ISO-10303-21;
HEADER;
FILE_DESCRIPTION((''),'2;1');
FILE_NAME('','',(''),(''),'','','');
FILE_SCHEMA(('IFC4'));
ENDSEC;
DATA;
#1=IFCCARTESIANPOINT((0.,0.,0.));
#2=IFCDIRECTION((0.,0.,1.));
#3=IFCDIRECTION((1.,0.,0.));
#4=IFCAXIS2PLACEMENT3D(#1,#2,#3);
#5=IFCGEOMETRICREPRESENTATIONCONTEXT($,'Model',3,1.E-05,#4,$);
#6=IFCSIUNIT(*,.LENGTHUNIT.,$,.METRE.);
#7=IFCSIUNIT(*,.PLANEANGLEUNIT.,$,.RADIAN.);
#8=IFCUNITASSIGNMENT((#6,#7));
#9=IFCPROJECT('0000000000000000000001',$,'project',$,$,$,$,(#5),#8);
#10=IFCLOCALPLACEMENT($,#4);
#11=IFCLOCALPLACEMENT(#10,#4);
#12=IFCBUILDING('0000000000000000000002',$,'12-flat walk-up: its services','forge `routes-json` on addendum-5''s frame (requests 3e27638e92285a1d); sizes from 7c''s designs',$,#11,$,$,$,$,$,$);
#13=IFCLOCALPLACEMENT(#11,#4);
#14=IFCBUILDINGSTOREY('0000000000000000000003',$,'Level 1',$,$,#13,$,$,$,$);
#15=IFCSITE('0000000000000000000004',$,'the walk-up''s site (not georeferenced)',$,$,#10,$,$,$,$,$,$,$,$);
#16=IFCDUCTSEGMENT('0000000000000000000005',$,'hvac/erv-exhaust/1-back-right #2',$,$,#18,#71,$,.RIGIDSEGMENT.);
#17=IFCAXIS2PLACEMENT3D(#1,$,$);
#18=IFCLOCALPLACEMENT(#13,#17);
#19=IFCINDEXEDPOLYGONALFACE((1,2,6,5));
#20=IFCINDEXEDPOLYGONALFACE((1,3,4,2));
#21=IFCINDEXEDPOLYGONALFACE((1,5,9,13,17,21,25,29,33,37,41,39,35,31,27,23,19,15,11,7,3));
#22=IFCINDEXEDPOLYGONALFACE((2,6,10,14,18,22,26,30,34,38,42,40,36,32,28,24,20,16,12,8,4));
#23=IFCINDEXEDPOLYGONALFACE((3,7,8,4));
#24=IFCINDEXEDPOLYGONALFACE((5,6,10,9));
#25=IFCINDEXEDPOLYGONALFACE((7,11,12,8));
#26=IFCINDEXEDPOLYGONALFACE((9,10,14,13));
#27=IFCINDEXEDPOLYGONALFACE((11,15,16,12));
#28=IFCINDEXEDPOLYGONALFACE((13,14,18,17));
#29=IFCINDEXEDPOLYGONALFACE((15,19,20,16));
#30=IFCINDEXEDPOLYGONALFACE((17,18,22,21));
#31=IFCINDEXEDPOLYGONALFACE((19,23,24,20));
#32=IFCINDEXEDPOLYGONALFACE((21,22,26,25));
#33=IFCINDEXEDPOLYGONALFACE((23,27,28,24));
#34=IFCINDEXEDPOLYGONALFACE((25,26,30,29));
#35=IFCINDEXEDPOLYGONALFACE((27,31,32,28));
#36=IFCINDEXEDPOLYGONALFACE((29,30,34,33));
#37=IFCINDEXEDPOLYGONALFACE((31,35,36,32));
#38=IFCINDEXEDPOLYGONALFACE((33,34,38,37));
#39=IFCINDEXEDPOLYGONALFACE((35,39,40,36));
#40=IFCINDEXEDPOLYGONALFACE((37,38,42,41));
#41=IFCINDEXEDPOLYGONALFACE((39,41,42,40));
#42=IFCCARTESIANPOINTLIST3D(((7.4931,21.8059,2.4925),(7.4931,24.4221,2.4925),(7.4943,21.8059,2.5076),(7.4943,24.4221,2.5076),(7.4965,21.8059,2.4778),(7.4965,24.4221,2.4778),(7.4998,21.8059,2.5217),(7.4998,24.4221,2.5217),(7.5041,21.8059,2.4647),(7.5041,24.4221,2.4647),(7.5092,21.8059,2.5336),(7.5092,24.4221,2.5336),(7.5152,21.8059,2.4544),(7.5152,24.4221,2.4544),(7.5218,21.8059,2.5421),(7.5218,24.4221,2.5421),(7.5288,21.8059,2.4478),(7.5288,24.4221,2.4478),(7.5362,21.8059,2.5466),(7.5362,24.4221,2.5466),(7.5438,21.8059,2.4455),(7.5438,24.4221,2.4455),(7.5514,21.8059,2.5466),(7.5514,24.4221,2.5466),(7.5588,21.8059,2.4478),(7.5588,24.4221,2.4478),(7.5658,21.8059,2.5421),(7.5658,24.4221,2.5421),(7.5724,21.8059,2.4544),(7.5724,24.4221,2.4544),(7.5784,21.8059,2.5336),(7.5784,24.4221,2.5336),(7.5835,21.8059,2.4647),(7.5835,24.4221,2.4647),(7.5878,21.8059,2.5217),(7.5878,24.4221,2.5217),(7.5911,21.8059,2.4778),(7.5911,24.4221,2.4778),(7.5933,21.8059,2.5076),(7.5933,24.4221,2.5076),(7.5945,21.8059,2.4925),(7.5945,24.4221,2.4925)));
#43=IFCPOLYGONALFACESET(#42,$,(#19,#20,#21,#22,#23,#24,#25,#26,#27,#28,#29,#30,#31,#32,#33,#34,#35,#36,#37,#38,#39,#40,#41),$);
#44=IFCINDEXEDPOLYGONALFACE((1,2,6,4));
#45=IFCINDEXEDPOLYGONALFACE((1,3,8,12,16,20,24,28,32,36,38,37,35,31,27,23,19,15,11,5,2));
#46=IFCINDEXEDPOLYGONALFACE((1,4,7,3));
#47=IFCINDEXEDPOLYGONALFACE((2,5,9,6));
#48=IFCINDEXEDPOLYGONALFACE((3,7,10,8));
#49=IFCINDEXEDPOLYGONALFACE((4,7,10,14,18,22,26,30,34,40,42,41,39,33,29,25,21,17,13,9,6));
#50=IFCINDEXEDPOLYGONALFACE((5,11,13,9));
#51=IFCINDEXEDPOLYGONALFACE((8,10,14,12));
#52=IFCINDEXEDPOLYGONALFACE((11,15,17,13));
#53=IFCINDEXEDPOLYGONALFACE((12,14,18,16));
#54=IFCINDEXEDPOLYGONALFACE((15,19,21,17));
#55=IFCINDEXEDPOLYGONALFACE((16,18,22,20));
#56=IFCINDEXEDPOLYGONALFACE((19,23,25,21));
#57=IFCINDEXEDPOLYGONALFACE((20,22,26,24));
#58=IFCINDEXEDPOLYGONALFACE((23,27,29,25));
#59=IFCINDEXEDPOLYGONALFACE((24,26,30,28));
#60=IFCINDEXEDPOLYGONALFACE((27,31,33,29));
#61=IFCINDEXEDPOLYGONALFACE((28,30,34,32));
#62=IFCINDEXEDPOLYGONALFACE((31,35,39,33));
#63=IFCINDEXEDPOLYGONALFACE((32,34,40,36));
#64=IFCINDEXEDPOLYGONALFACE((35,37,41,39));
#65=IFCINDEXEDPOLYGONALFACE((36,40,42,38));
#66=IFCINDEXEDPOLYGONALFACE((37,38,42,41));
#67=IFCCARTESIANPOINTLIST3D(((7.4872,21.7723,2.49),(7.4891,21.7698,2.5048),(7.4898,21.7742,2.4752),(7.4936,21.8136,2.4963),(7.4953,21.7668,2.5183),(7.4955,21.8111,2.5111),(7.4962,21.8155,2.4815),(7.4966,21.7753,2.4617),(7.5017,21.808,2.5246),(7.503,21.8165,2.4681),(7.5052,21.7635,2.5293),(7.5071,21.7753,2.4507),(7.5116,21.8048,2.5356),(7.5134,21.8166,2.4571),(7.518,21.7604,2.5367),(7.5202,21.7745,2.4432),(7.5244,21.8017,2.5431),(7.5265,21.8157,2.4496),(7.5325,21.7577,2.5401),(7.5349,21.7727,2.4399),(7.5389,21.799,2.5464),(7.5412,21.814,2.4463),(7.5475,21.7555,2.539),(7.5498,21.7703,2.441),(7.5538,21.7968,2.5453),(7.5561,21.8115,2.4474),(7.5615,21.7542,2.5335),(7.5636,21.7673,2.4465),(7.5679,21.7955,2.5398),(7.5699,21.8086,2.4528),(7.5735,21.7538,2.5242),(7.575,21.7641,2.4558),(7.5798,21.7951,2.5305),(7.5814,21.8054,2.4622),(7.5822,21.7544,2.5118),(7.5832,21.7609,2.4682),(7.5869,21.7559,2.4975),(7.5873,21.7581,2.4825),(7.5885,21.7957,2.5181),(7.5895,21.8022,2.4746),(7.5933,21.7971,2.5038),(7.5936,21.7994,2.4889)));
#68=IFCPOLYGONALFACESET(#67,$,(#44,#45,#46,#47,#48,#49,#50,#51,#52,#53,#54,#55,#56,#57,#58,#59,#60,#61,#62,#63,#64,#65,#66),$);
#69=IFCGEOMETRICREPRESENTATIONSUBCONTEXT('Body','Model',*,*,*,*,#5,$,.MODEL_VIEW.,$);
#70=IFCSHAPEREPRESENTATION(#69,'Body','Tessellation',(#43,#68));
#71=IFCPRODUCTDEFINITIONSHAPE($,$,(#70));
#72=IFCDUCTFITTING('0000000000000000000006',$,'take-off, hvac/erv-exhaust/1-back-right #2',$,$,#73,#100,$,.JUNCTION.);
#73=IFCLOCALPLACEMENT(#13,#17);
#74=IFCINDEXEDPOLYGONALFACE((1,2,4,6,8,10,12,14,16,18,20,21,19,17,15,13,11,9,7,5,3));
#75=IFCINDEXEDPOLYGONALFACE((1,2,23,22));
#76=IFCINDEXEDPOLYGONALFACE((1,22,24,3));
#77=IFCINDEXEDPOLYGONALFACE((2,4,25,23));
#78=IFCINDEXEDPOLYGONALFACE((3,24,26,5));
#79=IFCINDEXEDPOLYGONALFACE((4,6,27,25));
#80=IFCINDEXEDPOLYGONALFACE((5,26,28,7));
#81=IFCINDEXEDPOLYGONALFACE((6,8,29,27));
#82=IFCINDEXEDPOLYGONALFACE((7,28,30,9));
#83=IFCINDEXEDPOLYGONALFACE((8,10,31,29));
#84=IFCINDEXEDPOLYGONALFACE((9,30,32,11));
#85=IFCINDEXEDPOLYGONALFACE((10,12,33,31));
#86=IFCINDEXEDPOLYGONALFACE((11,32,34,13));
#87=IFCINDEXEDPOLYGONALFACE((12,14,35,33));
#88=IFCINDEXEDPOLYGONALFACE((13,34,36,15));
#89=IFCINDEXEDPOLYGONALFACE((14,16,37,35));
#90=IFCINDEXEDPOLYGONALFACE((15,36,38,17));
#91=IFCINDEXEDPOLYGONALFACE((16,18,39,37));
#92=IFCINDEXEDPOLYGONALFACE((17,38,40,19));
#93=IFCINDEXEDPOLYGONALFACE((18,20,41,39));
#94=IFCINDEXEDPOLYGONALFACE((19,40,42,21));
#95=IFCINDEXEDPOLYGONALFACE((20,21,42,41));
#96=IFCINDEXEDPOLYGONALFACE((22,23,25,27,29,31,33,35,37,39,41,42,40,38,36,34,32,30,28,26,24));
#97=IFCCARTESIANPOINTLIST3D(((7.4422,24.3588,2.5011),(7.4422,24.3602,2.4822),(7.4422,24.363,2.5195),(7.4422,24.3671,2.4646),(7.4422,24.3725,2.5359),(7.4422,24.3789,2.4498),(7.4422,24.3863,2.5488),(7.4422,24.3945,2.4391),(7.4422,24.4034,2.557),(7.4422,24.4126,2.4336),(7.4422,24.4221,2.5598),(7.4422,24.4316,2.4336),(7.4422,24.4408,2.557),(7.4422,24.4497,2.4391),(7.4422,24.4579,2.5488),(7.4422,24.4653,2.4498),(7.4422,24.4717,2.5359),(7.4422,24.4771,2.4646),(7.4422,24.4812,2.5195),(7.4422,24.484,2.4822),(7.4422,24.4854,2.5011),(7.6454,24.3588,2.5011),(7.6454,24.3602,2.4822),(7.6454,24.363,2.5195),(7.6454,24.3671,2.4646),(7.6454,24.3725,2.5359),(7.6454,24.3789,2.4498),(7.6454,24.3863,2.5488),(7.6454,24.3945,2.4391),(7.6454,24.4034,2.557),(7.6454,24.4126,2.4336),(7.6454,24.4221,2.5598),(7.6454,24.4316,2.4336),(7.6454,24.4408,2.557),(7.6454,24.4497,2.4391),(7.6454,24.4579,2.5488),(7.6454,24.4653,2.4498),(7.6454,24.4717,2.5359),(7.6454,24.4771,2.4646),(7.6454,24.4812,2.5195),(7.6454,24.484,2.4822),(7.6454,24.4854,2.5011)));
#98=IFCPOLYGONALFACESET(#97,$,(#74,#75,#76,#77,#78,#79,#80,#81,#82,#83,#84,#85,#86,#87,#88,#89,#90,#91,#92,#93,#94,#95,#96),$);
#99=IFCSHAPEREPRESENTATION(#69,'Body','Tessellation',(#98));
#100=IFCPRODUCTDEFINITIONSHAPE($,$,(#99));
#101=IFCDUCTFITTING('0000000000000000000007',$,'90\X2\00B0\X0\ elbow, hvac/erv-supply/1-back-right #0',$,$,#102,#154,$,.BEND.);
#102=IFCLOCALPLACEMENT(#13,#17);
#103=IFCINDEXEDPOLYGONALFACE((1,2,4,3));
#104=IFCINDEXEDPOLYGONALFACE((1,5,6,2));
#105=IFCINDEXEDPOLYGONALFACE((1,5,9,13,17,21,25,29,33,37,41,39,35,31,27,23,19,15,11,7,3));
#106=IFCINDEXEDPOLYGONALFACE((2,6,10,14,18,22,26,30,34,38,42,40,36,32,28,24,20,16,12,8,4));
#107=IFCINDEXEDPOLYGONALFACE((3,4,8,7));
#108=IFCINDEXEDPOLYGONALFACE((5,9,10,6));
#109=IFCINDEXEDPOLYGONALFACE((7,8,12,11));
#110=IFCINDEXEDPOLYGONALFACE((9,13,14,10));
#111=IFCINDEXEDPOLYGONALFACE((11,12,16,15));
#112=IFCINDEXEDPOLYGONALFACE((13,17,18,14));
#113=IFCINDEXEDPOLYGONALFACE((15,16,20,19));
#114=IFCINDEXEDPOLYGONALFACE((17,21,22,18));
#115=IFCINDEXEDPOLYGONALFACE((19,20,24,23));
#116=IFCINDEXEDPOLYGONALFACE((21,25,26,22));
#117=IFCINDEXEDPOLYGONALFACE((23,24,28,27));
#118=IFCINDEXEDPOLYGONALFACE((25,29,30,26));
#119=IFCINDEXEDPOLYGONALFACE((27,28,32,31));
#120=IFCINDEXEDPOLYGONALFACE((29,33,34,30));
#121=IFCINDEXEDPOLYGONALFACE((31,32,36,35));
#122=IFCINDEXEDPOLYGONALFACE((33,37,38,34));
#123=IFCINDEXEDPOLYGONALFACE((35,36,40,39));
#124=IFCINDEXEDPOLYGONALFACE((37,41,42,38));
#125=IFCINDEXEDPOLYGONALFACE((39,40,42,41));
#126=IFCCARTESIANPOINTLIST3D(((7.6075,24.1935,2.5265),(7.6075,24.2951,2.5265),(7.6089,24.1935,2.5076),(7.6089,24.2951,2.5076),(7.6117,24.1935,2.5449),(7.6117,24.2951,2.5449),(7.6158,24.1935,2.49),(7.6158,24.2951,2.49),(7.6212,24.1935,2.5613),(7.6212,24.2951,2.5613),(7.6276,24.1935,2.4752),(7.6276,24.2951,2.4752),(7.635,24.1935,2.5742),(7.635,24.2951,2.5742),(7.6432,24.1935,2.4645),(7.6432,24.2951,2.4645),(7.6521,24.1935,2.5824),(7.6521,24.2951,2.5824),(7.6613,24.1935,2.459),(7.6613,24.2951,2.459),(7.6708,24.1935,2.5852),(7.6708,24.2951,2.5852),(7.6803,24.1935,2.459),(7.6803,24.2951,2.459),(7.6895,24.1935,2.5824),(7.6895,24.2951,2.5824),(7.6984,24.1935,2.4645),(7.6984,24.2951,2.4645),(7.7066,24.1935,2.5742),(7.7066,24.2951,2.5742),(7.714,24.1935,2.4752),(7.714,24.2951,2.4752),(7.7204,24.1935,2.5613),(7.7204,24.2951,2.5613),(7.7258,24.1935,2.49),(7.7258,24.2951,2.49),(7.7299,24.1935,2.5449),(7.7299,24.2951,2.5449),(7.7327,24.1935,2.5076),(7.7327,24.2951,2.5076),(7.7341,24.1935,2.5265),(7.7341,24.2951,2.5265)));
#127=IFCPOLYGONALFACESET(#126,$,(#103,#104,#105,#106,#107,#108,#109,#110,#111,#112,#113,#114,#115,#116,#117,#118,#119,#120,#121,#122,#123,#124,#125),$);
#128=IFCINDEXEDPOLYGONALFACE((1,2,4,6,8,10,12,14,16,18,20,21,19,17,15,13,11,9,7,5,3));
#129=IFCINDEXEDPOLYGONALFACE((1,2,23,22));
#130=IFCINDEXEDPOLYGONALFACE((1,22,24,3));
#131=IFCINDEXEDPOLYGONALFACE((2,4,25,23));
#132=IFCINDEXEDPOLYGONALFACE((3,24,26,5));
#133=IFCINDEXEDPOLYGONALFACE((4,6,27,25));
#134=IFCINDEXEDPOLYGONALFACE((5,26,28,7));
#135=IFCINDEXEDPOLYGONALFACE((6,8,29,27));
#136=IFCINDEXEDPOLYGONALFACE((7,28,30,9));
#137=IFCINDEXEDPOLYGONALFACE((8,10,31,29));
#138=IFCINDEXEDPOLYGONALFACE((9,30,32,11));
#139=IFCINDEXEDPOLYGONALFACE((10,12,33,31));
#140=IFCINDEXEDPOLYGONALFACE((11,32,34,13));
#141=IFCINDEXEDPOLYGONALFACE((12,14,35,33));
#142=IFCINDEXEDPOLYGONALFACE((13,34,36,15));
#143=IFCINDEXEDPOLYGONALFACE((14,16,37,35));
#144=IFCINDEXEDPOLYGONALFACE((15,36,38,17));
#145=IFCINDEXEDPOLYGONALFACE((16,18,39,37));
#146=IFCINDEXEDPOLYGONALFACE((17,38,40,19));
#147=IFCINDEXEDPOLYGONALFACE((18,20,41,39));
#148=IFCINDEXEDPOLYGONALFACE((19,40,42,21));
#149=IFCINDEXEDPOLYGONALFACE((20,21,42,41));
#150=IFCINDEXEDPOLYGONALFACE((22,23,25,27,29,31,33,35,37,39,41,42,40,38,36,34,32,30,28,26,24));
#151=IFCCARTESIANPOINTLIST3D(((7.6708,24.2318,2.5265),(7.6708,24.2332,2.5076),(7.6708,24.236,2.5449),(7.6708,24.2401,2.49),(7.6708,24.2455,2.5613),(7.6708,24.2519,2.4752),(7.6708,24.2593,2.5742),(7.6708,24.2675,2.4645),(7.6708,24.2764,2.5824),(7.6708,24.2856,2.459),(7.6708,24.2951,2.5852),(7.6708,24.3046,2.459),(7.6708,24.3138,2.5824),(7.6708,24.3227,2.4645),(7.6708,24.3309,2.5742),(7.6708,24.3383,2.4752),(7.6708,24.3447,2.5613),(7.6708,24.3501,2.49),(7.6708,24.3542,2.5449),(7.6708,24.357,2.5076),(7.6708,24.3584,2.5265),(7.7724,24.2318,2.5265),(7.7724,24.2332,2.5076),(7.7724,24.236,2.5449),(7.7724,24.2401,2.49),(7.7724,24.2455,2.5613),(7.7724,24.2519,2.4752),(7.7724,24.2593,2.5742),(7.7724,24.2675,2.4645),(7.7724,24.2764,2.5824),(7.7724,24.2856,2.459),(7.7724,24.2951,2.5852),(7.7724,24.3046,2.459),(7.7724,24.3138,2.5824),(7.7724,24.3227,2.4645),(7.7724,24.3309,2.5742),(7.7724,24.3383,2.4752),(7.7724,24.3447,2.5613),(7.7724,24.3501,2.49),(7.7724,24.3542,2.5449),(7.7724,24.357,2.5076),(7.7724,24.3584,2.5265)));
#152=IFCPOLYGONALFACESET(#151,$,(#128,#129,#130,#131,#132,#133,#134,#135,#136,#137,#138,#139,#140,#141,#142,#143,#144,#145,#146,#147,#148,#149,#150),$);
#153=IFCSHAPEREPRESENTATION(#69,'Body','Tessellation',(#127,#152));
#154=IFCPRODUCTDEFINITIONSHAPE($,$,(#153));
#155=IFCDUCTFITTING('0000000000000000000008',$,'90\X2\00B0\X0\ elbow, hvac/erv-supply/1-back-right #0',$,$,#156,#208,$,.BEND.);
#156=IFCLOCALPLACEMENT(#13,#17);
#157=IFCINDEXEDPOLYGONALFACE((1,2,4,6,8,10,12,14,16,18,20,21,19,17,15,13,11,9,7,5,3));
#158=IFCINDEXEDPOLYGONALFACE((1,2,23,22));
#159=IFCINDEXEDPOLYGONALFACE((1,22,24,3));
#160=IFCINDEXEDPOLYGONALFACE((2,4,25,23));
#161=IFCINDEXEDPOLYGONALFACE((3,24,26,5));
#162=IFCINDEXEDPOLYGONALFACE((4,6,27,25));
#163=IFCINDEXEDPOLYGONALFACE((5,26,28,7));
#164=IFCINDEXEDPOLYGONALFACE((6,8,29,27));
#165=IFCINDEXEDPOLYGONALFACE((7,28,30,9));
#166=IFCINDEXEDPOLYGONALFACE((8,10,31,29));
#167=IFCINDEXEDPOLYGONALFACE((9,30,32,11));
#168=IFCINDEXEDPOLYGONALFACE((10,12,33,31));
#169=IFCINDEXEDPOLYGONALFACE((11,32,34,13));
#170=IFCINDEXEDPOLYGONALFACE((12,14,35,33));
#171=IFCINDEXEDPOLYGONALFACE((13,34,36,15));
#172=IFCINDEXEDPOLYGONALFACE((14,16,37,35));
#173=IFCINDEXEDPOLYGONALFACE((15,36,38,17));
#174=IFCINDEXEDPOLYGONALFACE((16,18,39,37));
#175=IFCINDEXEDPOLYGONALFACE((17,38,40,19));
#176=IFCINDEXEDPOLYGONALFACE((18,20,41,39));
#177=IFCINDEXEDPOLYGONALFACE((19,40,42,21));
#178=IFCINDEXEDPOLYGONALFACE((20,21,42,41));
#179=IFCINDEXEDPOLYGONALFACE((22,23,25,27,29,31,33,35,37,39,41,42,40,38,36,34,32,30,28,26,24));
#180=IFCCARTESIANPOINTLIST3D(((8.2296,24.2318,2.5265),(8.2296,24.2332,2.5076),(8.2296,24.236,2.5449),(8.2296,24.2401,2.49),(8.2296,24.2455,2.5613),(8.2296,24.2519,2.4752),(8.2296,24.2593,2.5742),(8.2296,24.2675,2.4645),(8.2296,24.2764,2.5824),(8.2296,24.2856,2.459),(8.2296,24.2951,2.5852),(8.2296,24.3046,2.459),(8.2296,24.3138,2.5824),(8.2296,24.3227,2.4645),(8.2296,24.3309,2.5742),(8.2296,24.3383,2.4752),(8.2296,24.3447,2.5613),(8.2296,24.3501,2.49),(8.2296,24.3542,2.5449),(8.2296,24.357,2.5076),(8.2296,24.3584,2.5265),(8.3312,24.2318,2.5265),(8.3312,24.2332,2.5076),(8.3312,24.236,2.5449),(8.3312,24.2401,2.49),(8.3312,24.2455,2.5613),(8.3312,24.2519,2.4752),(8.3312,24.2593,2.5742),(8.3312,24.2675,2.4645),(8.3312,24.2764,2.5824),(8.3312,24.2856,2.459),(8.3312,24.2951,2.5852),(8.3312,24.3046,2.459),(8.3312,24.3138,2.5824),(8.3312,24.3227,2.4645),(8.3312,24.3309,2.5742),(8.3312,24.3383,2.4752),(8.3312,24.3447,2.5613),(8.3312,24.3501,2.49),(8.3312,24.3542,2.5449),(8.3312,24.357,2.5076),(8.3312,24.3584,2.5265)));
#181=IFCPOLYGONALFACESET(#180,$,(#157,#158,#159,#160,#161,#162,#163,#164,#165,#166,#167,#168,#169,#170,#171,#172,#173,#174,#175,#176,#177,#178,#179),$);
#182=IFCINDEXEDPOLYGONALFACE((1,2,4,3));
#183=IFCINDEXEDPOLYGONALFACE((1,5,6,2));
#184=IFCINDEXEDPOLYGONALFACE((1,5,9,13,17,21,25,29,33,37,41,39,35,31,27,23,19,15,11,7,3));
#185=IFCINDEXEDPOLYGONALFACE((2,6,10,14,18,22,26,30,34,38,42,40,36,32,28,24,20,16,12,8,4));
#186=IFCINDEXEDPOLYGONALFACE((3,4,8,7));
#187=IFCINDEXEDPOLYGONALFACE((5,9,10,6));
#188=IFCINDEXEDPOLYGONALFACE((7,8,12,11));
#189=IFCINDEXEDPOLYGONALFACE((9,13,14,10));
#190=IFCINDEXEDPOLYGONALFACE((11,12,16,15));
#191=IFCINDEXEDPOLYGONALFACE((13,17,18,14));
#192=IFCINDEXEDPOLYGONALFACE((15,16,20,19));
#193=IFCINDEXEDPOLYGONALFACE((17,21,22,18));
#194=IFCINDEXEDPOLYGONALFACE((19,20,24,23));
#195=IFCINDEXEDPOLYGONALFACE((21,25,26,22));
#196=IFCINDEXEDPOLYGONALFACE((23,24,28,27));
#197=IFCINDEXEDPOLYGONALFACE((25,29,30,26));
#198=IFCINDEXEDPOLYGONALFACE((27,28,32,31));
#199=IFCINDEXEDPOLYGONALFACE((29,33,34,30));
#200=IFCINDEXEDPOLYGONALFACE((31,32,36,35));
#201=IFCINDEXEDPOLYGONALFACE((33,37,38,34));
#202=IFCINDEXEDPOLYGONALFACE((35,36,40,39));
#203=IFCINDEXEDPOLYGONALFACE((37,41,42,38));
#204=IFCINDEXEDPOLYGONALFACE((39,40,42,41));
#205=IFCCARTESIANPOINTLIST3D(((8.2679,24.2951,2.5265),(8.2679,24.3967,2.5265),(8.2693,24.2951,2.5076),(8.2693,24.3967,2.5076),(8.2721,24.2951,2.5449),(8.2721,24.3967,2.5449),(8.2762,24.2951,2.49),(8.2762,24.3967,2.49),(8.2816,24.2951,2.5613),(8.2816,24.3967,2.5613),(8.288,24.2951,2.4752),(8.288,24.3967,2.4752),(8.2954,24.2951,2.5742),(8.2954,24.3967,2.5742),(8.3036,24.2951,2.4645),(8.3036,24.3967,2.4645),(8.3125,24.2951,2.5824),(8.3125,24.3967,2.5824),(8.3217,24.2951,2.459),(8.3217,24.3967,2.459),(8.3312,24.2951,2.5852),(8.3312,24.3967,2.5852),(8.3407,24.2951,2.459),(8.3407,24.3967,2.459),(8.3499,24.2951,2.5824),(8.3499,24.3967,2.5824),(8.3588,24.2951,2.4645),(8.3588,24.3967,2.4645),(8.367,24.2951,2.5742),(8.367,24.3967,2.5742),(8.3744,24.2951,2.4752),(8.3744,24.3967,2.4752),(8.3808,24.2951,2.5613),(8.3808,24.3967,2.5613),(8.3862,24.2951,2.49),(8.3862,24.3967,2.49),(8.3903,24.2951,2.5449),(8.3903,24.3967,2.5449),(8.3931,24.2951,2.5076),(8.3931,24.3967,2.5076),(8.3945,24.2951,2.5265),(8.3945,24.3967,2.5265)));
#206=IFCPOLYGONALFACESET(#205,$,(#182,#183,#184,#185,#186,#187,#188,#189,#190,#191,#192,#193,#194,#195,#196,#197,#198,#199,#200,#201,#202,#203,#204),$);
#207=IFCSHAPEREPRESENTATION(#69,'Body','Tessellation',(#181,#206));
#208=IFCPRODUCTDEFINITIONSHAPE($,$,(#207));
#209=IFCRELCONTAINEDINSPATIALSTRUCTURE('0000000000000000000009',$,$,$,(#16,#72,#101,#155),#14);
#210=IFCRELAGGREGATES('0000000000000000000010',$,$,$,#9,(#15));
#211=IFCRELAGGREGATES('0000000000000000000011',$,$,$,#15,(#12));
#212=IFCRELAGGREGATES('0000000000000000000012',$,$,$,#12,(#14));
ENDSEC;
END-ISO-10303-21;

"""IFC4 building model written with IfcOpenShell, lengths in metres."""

from ifc_helpers import new_model, entity, si_unit, frame, origin_with_axes, place, context, subcontext, project, spatial, element, save


model = new_model("IFC4")

# Units and contexts
model_context = context("Model", 3, precision=1e-05, world=origin_with_axes())
body_context = subcontext(model_context, "Body", "Model", "MODEL_VIEW")
ifc_project = project(units=[si_unit("LENGTHUNIT", "METRE"), si_unit("PLANEANGLEUNIT", "RADIAN")], contexts=[model_context])

# Site, building, storey
site_placement = place(None, origin_with_axes())
site = spatial("IfcSite", under=ifc_project, at=site_placement, Name="the walk-up's site (not georeferenced)")
building_placement = place(site_placement, origin_with_axes())
building = spatial("IfcBuilding", under=site, at=building_placement, Name="12-flat walk-up: its services", Description="forge `routes-json` on addendum-5's frame (requests 3e27638e92285a1d); sizes from 7c's designs")
storey_placement = place(building_placement, origin_with_axes())
storey = spatial("IfcBuildingStorey", under=building, at=storey_placement, Name="Level 1")

# Duct segment
duct_segment_1_placement = place(storey_placement, frame((7.5438, 24.4221, 2.4963), z_axis=(0.0, 0.0, 1.0), x_axis=(1.0, 0.0, 0.0)))
element("IfcDuctSegment", 1, at=duct_segment_1_placement, inside=storey, Name="hvac/erv-exhaust/1-back-right #2", PredefinedType="RIGIDSEGMENT", context=body_context, shape_type="AdvancedSweptSolid", body=[
    entity("IfcSweptDiskSolid", entity("IfcPolyline", [entity("IfcCartesianPoint", [0.0, 0.0, 0.0]), entity("IfcCartesianPoint", [0.0, -2.6162, 0.0])]), 0.0508),
    entity("IfcSweptDiskSolid", entity("IfcPolyline", [entity("IfcCartesianPoint", [0.0, -2.6162, 0.0]), entity("IfcCartesianPoint", [-0.0063, -2.6575, -0.0063])]), 0.0508),
])

# Duct fittings
duct_fitting_1_placement = place(storey_placement, frame((7.4422, 24.4221, 2.4963), z_axis=(0.0, 0.0, 1.0), x_axis=(1.0, 0.0, 0.0)))
element("IfcDuctFitting", 2, at=duct_fitting_1_placement, inside=storey, Name="take-off, hvac/erv-exhaust/1-back-right #2", PredefinedType="JUNCTION", context=body_context, shape_type="AdvancedSweptSolid", body=[
    entity("IfcSweptDiskSolid", entity("IfcPolyline", [entity("IfcCartesianPoint", [0.0, 0.0, 0.0]), entity("IfcCartesianPoint", [0.2032, 0.0, 0.0])]), 0.0635),
])
duct_fitting_2_placement = place(storey_placement, frame((7.6708, 24.1935, 2.5217), z_axis=(0.0, 0.0, 1.0), x_axis=(1.0, 0.0, 0.0)))
element("IfcDuctFitting", 3, at=duct_fitting_2_placement, inside=storey, Name="90° elbow, hvac/erv-supply/1-back-right #0", PredefinedType="BEND", context=body_context, shape_type="AdvancedSweptSolid", body=[
    entity("IfcSweptDiskSolid", entity("IfcPolyline", [entity("IfcCartesianPoint", [0.0, 0.0, 0.0]), entity("IfcCartesianPoint", [0.0, 0.1016, 0.0])]), 0.0635),
    entity("IfcSweptDiskSolid", entity("IfcPolyline", [entity("IfcCartesianPoint", [0.0, 0.1016, 0.0]), entity("IfcCartesianPoint", [0.1016, 0.1016, 0.0])]), 0.0635),
])
duct_fitting_3_placement = place(storey_placement, frame((8.2296, 24.2951, 2.5217), z_axis=(0.0, 0.0, 1.0), x_axis=(1.0, 0.0, 0.0)))
element("IfcDuctFitting", 4, at=duct_fitting_3_placement, inside=storey, Name="90° elbow, hvac/erv-supply/1-back-right #0", PredefinedType="BEND", context=body_context, shape_type="AdvancedSweptSolid", body=[
    entity("IfcSweptDiskSolid", entity("IfcPolyline", [entity("IfcCartesianPoint", [0.0, 0.0, 0.0]), entity("IfcCartesianPoint", [0.1016, 0.0, 0.0])]), 0.0635),
    entity("IfcSweptDiskSolid", entity("IfcPolyline", [entity("IfcCartesianPoint", [0.1016, 0.0, 0.0]), entity("IfcCartesianPoint", [0.1016, 0.1016, 0.0])]), 0.0635),
])

save(model, "model.ifc")
